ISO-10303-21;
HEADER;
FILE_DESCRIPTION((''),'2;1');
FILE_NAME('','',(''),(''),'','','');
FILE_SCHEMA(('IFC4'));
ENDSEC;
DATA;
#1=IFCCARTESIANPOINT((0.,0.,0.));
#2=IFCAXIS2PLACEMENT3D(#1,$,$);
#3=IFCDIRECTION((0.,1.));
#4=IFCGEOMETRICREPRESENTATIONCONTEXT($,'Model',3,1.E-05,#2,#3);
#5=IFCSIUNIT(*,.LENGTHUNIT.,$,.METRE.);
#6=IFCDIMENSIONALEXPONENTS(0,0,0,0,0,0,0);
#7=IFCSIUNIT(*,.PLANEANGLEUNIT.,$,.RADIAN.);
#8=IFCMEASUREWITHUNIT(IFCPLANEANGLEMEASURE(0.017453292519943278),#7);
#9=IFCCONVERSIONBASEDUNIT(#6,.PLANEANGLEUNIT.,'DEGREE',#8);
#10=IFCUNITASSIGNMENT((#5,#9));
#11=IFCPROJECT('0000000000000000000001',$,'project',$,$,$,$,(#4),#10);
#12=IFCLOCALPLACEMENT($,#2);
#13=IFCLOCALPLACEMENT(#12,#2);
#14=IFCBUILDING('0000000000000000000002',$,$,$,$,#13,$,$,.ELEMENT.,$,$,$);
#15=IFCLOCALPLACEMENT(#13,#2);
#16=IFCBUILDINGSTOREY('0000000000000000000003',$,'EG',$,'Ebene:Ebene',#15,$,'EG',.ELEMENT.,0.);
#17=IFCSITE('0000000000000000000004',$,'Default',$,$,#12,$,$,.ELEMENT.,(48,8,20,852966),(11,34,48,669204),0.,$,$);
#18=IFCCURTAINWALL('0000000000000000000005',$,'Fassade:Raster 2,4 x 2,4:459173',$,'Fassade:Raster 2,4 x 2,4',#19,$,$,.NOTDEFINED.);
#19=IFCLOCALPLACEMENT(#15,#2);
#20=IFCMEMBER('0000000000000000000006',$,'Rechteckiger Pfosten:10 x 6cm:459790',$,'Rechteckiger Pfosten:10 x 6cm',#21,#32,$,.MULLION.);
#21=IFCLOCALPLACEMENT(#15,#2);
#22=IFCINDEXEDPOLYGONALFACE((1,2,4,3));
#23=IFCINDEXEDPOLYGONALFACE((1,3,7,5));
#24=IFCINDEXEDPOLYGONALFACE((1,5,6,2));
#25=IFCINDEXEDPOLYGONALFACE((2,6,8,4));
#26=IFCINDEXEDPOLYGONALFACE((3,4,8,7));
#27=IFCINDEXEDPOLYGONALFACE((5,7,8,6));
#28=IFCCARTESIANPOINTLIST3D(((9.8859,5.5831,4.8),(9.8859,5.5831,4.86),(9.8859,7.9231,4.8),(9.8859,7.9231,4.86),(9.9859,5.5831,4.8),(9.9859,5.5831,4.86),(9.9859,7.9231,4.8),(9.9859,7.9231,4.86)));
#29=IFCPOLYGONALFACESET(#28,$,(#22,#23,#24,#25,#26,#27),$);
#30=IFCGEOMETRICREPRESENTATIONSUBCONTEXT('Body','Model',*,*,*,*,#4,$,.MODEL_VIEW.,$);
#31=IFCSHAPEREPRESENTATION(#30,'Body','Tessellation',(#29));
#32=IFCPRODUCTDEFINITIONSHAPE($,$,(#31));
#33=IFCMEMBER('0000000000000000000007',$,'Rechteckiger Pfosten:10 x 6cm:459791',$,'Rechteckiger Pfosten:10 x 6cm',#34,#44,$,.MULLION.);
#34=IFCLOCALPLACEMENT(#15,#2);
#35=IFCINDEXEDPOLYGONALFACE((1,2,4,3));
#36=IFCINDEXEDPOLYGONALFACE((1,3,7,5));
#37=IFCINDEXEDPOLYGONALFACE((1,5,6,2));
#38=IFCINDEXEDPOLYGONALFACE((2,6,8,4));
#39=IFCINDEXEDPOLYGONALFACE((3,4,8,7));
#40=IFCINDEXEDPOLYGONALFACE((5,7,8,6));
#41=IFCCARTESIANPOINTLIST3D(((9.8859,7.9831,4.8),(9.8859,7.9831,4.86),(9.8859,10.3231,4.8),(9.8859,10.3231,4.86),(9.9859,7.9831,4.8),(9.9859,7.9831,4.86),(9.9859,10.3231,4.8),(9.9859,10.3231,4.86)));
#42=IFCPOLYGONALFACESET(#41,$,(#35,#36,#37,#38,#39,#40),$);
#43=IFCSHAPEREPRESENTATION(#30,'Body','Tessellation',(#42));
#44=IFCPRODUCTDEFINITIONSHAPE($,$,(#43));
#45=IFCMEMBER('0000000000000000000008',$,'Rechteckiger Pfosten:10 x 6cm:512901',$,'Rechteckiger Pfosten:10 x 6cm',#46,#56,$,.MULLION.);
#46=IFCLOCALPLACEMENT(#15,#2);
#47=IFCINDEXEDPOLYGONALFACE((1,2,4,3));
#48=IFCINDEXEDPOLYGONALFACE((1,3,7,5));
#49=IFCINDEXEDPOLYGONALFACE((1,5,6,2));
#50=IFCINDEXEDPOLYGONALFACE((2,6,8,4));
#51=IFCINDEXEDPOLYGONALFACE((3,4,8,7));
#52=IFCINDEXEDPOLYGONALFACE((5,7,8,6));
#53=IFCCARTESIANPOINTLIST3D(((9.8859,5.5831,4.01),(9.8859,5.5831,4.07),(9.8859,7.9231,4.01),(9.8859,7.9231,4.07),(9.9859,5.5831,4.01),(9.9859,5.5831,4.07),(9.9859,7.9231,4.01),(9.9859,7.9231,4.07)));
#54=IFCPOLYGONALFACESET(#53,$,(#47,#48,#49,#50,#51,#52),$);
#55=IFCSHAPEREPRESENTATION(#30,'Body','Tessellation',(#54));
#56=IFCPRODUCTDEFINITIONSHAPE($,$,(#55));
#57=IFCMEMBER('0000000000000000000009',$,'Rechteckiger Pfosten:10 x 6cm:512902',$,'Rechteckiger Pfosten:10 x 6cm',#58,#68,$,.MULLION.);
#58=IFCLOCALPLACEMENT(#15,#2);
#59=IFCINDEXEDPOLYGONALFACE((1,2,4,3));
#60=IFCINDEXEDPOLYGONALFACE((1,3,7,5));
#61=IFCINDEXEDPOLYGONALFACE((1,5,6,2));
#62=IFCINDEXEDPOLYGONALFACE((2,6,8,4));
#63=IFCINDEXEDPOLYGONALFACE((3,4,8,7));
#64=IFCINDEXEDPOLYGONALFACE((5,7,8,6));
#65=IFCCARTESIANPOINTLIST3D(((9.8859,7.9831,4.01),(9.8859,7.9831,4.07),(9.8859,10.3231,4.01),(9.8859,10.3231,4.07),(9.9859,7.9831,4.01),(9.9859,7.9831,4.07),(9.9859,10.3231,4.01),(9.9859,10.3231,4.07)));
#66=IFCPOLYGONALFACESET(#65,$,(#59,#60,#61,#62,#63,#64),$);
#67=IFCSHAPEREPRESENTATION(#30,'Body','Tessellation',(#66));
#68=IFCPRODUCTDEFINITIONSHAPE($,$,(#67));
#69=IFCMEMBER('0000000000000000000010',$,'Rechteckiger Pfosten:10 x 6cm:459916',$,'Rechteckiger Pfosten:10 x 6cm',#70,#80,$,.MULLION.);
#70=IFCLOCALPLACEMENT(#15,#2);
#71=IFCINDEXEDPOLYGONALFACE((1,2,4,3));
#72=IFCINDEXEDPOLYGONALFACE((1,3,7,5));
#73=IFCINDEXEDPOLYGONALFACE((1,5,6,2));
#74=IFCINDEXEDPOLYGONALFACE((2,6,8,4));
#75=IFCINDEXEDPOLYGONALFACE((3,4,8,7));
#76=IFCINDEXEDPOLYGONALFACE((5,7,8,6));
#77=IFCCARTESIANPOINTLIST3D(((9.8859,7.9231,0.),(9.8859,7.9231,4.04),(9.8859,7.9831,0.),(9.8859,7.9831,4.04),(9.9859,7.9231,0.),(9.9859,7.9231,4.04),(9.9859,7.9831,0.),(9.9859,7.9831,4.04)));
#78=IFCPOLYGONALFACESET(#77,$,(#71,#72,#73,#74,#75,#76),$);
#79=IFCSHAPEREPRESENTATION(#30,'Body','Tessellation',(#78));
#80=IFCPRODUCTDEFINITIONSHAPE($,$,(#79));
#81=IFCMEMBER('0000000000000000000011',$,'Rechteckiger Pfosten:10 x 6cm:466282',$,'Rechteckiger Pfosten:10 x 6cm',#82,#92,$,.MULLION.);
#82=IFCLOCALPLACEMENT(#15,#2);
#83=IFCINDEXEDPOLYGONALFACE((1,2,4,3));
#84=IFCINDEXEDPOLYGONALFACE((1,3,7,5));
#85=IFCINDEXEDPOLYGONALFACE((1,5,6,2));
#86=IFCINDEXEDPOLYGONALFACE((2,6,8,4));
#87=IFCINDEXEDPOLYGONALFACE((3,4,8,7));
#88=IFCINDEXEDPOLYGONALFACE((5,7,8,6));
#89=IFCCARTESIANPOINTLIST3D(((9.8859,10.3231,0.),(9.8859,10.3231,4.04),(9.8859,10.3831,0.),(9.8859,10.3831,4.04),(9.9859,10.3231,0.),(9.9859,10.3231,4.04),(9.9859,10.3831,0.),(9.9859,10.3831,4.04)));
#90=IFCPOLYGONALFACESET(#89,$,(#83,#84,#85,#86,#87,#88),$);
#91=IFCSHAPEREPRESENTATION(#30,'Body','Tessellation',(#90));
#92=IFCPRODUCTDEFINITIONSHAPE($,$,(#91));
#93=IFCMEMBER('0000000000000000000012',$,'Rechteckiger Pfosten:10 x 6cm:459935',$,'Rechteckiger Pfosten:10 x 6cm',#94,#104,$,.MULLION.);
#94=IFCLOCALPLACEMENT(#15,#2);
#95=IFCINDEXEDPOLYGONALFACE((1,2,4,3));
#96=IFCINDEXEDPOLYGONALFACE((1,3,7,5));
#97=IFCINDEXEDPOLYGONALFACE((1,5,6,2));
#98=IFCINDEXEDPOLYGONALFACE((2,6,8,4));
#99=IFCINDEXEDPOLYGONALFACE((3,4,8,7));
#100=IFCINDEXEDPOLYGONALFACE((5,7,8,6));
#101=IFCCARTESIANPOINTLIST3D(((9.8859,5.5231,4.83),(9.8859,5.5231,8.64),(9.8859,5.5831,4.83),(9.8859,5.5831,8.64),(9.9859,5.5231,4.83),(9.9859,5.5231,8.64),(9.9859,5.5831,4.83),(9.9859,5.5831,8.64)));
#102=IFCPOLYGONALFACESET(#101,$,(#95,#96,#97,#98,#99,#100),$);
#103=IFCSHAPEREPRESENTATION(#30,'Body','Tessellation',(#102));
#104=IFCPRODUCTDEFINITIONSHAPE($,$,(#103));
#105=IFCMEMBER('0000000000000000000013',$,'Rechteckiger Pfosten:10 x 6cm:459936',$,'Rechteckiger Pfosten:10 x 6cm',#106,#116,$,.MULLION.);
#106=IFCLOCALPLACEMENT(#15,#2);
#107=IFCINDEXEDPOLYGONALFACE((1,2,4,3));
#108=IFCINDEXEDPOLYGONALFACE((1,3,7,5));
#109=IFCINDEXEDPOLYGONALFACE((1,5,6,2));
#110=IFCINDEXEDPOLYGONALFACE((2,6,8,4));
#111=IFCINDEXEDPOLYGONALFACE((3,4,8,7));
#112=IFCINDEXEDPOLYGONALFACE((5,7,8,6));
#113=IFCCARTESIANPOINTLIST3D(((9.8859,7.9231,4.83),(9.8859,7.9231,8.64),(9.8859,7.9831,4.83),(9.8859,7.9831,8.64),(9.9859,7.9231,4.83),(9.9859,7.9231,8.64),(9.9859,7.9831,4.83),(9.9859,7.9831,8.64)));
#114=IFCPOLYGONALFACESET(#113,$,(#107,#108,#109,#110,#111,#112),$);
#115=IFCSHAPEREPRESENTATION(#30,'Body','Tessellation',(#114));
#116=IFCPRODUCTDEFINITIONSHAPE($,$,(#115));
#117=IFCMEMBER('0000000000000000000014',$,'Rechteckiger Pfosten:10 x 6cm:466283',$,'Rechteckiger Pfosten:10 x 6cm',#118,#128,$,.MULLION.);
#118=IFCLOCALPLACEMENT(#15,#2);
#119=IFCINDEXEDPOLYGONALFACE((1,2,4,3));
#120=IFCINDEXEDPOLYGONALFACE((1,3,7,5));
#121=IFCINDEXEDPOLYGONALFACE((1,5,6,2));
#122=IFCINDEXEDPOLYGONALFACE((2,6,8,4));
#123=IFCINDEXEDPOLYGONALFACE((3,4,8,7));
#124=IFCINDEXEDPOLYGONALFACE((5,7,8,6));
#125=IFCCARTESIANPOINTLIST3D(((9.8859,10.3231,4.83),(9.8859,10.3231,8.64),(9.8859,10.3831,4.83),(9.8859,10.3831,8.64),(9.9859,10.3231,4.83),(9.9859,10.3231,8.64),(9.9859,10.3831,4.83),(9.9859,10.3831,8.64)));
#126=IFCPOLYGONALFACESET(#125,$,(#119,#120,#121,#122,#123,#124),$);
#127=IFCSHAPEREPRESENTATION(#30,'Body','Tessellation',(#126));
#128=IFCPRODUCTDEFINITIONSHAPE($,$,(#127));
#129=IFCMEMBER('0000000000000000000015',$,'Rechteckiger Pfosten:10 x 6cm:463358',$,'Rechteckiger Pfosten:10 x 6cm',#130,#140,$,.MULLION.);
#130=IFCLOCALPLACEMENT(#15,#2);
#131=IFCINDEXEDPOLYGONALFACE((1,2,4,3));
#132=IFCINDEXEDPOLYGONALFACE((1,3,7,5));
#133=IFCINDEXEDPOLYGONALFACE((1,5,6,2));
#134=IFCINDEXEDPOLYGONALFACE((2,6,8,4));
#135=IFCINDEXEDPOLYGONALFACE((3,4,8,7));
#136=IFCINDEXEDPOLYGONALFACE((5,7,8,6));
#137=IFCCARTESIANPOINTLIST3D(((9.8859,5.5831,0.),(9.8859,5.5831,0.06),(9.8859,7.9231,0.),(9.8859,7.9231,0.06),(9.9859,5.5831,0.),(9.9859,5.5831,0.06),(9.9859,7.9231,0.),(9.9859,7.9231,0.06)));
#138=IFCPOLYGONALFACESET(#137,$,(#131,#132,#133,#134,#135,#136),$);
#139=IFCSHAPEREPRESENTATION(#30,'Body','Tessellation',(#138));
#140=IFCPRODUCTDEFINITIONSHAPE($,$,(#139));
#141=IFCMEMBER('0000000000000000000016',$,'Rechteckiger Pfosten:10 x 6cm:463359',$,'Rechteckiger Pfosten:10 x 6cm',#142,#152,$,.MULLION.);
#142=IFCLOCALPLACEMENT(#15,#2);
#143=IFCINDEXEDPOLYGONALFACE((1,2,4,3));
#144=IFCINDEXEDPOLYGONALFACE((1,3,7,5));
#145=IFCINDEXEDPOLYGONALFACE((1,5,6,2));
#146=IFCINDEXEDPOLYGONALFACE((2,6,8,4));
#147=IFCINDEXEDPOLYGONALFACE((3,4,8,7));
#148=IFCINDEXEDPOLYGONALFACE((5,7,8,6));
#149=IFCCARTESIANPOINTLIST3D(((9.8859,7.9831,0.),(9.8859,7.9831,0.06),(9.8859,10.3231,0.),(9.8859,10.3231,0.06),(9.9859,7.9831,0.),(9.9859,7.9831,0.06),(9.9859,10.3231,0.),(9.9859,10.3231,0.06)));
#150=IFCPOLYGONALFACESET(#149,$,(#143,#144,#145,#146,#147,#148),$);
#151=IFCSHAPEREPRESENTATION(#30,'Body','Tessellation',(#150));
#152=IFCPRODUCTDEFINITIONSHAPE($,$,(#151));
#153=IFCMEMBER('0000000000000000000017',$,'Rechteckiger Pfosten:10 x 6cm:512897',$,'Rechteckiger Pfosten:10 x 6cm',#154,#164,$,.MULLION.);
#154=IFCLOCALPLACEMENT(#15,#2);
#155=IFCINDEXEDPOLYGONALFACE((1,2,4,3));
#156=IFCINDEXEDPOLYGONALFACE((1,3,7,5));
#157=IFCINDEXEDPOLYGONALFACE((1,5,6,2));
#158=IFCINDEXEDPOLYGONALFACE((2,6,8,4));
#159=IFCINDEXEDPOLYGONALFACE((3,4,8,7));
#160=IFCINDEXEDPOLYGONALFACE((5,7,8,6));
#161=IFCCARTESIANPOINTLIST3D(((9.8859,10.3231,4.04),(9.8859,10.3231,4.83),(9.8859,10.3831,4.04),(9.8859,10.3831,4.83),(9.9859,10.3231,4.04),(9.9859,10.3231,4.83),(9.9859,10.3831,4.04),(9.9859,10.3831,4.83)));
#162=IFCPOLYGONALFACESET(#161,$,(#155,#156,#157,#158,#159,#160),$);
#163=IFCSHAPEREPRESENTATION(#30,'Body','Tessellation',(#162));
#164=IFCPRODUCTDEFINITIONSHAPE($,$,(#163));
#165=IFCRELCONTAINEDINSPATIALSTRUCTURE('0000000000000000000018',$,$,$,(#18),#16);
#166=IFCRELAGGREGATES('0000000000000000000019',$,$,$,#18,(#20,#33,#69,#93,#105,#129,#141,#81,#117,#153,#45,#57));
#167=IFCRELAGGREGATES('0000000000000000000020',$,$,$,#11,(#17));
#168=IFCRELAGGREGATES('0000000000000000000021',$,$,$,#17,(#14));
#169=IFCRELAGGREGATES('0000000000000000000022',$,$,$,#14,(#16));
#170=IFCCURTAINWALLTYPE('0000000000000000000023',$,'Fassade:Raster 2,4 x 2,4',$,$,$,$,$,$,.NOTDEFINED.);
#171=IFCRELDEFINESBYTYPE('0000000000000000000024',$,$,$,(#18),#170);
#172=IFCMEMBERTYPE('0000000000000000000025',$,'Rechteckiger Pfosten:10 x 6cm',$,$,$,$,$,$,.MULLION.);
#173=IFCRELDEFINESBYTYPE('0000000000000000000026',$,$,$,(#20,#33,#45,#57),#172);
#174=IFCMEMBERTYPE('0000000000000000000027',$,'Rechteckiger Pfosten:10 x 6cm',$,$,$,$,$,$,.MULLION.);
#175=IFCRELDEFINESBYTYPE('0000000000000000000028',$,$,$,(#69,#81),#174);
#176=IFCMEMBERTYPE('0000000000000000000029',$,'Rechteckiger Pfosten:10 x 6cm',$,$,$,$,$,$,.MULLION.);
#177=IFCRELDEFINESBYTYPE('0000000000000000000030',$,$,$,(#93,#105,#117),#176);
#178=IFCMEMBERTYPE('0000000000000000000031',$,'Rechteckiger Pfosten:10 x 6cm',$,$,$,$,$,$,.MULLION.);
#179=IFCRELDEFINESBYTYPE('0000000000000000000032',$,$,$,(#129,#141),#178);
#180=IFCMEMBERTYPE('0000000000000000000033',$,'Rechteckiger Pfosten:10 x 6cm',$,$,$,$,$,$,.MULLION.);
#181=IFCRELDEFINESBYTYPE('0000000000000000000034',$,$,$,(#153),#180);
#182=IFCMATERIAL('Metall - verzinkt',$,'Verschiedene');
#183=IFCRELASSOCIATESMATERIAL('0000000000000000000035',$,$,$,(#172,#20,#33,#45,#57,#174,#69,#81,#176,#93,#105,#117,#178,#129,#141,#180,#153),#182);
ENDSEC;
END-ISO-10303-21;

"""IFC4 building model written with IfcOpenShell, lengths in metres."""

from ifc_helpers import new_model, entity, si_unit, converted_unit, direction, frame, origin, place, context, subcontext, project, spatial, indexed_curve, outline, extrude, source, transform, mapped, material, type_object, type_shapes, element, aggregate, save


model = new_model("IFC4")

# Units and contexts
model_context = context("Model", 3, precision=1e-05, world=origin(), true_north=direction((0.0, 1.0)))
body_context = subcontext(model_context, "Body", "Model", "MODEL_VIEW")
ifc_project = project(units=[si_unit("LENGTHUNIT", "METRE"), converted_unit("PLANEANGLEUNIT", "DEGREE", entity("IfcPlaneAngleMeasure", 0.017453292519943278), si_unit("PLANEANGLEUNIT", "RADIAN"), dimensions=[0, 0, 0, 0, 0, 0, 0])], contexts=[model_context])

# Site, building, storey
site_placement = place(None, origin())
site = spatial("IfcSite", under=ifc_project, at=site_placement, Name="Default", CompositionType="ELEMENT", RefLatitude=(48, 8, 20, 852966), RefLongitude=(11, 34, 48, 669204), RefElevation=0.0)
building_placement = place(site_placement, origin())
building = spatial("IfcBuilding", under=site, at=building_placement, CompositionType="ELEMENT")
storey_placement = place(building_placement, origin())
storey = spatial("IfcBuildingStorey", under=building, at=storey_placement, Name="EG", ObjectType="Ebene:Ebene", LongName="EG", CompositionType="ELEMENT", Elevation=0.0)

# Curtain wall, members
curtain_wall_type = type_object("IfcCurtainWallType", Name="Fassade:Raster 2,4 x 2,4", PredefinedType="NOTDEFINED")
curtain_wall_placement = place(storey_placement, origin())
curtain_wall = element("IfcCurtainWall", 1, at=curtain_wall_placement, inside=storey, type_object=curtain_wall_type, Name="Fassade:Raster 2,4 x 2,4:459173", ObjectType="Fassade:Raster 2,4 x 2,4", PredefinedType="NOTDEFINED")
ifc_material_1 = material(Name="Metall - verzinkt", Category="Verschiedene")
member_type_1 = type_object("IfcMemberType", Name="Rechteckiger Pfosten:10 x 6cm", PredefinedType="MULLION", material=ifc_material_1)
shared_shape_1 = source(origin(), body_context, "Body", "SweptSolid", [
    extrude(outline(indexed_curve([(-0.03, -0.05), (0.03, -0.05), (0.03, 0.05), (-0.03, 0.05), (-0.03, -0.05)], self_intersect=False)), frame((0.0, 0.0, -2.34), z_axis=(0.0, 0.0, 1.0), x_axis=(-1.0, 0.0, 0.0)), (0.0, 0.0, 1.0), 2.34),
])
type_shapes(member_type_1, [shared_shape_1])
member_1_placement = place(curtain_wall_placement, frame((9.9359, 7.9231, 4.83), z_axis=(0.0, 1.0, 0.0), x_axis=(0.0, 0.0, 1.0)))
member_1 = element("IfcMember", 2, at=member_1_placement, type_object=member_type_1, material=ifc_material_1, Name="Rechteckiger Pfosten:10 x 6cm:459790", ObjectType="Rechteckiger Pfosten:10 x 6cm", PredefinedType="MULLION", context=body_context, shape_type="MappedRepresentation", body=[
    mapped(shared_shape_1, transform((0.0, 0.0, 0.0), scale=1.0)),
])
member_2_placement = place(curtain_wall_placement, frame((9.9359, 10.3231, 4.83), z_axis=(0.0, 1.0, 0.0), x_axis=(0.0, 0.0, 1.0)))
member_2 = element("IfcMember", 3, at=member_2_placement, type_object=member_type_1, material=ifc_material_1, Name="Rechteckiger Pfosten:10 x 6cm:459791", ObjectType="Rechteckiger Pfosten:10 x 6cm", PredefinedType="MULLION", context=body_context, shape_type="MappedRepresentation", body=[
    mapped(shared_shape_1, transform((0.0, 0.0, 0.0), scale=1.0)),
])
member_3_placement = place(curtain_wall_placement, frame((9.9359, 7.9231, 4.04), z_axis=(0.0, 1.0, 0.0), x_axis=(0.0, 0.0, 1.0)))
member_3 = element("IfcMember", 4, at=member_3_placement, type_object=member_type_1, material=ifc_material_1, Name="Rechteckiger Pfosten:10 x 6cm:512901", ObjectType="Rechteckiger Pfosten:10 x 6cm", PredefinedType="MULLION", context=body_context, shape_type="MappedRepresentation", body=[
    mapped(shared_shape_1, transform((0.0, 0.0, 0.0), scale=1.0)),
])
member_4_placement = place(curtain_wall_placement, frame((9.9359, 10.3231, 4.04), z_axis=(0.0, 1.0, 0.0), x_axis=(0.0, 0.0, 1.0)))
member_4 = element("IfcMember", 5, at=member_4_placement, type_object=member_type_1, material=ifc_material_1, Name="Rechteckiger Pfosten:10 x 6cm:512902", ObjectType="Rechteckiger Pfosten:10 x 6cm", PredefinedType="MULLION", context=body_context, shape_type="MappedRepresentation", body=[
    mapped(shared_shape_1, transform((0.0, 0.0, 0.0), scale=1.0)),
])
member_type_2 = type_object("IfcMemberType", Name="Rechteckiger Pfosten:10 x 6cm", PredefinedType="MULLION", material=ifc_material_1)
shared_shape_2 = source(origin(), body_context, "Body", "SweptSolid", [
    extrude(outline(indexed_curve([(-0.03, -0.05), (0.03, -0.05), (0.03, 0.05), (-0.03, 0.05), (-0.03, -0.05)], self_intersect=False)), frame((0.0, 0.0, -4.04), z_axis=(0.0, 0.0, 1.0), x_axis=(-1.0, 0.0, 0.0)), (0.0, 0.0, 1.0), 4.04),
])
type_shapes(member_type_2, [shared_shape_2])
member_5_placement = place(curtain_wall_placement, frame((9.9359, 7.9531, 0.0), z_axis=(0.0, 0.0, -1.0), x_axis=(0.0, 1.0, 0.0)))
member_5 = element("IfcMember", 6, at=member_5_placement, type_object=member_type_2, material=ifc_material_1, Name="Rechteckiger Pfosten:10 x 6cm:459916", ObjectType="Rechteckiger Pfosten:10 x 6cm", PredefinedType="MULLION", context=body_context, shape_type="MappedRepresentation", body=[
    mapped(shared_shape_2, transform((0.0, 0.0, 0.0), scale=1.0)),
])
member_6_placement = place(curtain_wall_placement, frame((9.9359, 10.3531, 0.0), z_axis=(0.0, 0.0, -1.0), x_axis=(0.0, 1.0, 0.0)))
member_6 = element("IfcMember", 7, at=member_6_placement, type_object=member_type_2, material=ifc_material_1, Name="Rechteckiger Pfosten:10 x 6cm:466282", ObjectType="Rechteckiger Pfosten:10 x 6cm", PredefinedType="MULLION", context=body_context, shape_type="MappedRepresentation", body=[
    mapped(shared_shape_2, transform((0.0, 0.0, 0.0), scale=1.0)),
])
member_type_3 = type_object("IfcMemberType", Name="Rechteckiger Pfosten:10 x 6cm", PredefinedType="MULLION", material=ifc_material_1)
shared_shape_3 = source(origin(), body_context, "Body", "SweptSolid", [
    extrude(outline(indexed_curve([(-0.03, -0.05), (0.03, -0.05), (0.03, 0.05), (-0.03, 0.05), (-0.03, -0.05)], self_intersect=False)), frame((0.0, 0.0, -3.81), z_axis=(0.0, 0.0, 1.0), x_axis=(-1.0, 0.0, 0.0)), (0.0, 0.0, 1.0), 3.81),
])
type_shapes(member_type_3, [shared_shape_3])
member_7_placement = place(curtain_wall_placement, frame((9.9359, 5.5531, 4.83), z_axis=(0.0, 0.0, -1.0), x_axis=(0.0, 1.0, 0.0)))
member_7 = element("IfcMember", 8, at=member_7_placement, type_object=member_type_3, material=ifc_material_1, Name="Rechteckiger Pfosten:10 x 6cm:459935", ObjectType="Rechteckiger Pfosten:10 x 6cm", PredefinedType="MULLION", context=body_context, shape_type="MappedRepresentation", body=[
    mapped(shared_shape_3, transform((0.0, 0.0, 0.0), scale=1.0)),
])
member_8_placement = place(curtain_wall_placement, frame((9.9359, 7.9531, 4.83), z_axis=(0.0, 0.0, -1.0), x_axis=(0.0, 1.0, 0.0)))
member_8 = element("IfcMember", 9, at=member_8_placement, type_object=member_type_3, material=ifc_material_1, Name="Rechteckiger Pfosten:10 x 6cm:459936", ObjectType="Rechteckiger Pfosten:10 x 6cm", PredefinedType="MULLION", context=body_context, shape_type="MappedRepresentation", body=[
    mapped(shared_shape_3, transform((0.0, 0.0, 0.0), scale=1.0)),
])
member_9_placement = place(curtain_wall_placement, frame((9.9359, 10.3531, 4.83), z_axis=(0.0, 0.0, -1.0), x_axis=(0.0, 1.0, 0.0)))
member_9 = element("IfcMember", 10, at=member_9_placement, type_object=member_type_3, material=ifc_material_1, Name="Rechteckiger Pfosten:10 x 6cm:466283", ObjectType="Rechteckiger Pfosten:10 x 6cm", PredefinedType="MULLION", context=body_context, shape_type="MappedRepresentation", body=[
    mapped(shared_shape_3, transform((0.0, 0.0, 0.0), scale=1.0)),
])
member_type_4 = type_object("IfcMemberType", Name="Rechteckiger Pfosten:10 x 6cm", PredefinedType="MULLION", material=ifc_material_1)
shared_shape_4 = source(origin(), body_context, "Body", "SweptSolid", [
    extrude(outline(indexed_curve([(-0.03, -0.05), (0.03, -0.05), (0.03, 0.05), (-0.03, 0.05), (-0.03, -0.05)], self_intersect=False)), frame((-0.03, 0.0, -2.34), z_axis=(0.0, 0.0, 1.0), x_axis=(-1.0, 0.0, 0.0)), (0.0, 0.0, 1.0), 2.34),
])
type_shapes(member_type_4, [shared_shape_4])
member_10_placement = place(curtain_wall_placement, frame((9.9359, 5.5831, 0.0), z_axis=(0.0, -1.0, 0.0), x_axis=(0.0, 0.0, -1.0)))
member_10 = element("IfcMember", 11, at=member_10_placement, type_object=member_type_4, material=ifc_material_1, Name="Rechteckiger Pfosten:10 x 6cm:463358", ObjectType="Rechteckiger Pfosten:10 x 6cm", PredefinedType="MULLION", context=body_context, shape_type="MappedRepresentation", body=[
    mapped(shared_shape_4, transform((0.0, 0.0, 0.0), scale=1.0)),
])
member_11_placement = place(curtain_wall_placement, frame((9.9359, 7.9831, 0.0), z_axis=(0.0, -1.0, 0.0), x_axis=(0.0, 0.0, -1.0)))
member_11 = element("IfcMember", 12, at=member_11_placement, type_object=member_type_4, material=ifc_material_1, Name="Rechteckiger Pfosten:10 x 6cm:463359", ObjectType="Rechteckiger Pfosten:10 x 6cm", PredefinedType="MULLION", context=body_context, shape_type="MappedRepresentation", body=[
    mapped(shared_shape_4, transform((0.0, 0.0, 0.0), scale=1.0)),
])
member_type_5 = type_object("IfcMemberType", Name="Rechteckiger Pfosten:10 x 6cm", PredefinedType="MULLION", material=ifc_material_1)
shared_shape_5 = source(origin(), body_context, "Body", "SweptSolid", [
    extrude(outline(indexed_curve([(-0.03, -0.05), (0.03, -0.05), (0.03, 0.05), (-0.03, 0.05), (-0.03, -0.05)], self_intersect=False)), frame((-0.03, 0.0, -0.79), z_axis=(0.0, 0.0, 1.0), x_axis=(-1.0, 0.0, 0.0)), (0.0, 0.0, 1.0), 0.79),
])
type_shapes(member_type_5, [shared_shape_5])
member_12_placement = place(curtain_wall_placement, frame((9.9359, 10.3831, 4.04), z_axis=(0.0, 0.0, -1.0), x_axis=(0.0, 1.0, 0.0)))
member_12 = element("IfcMember", 13, at=member_12_placement, type_object=member_type_5, material=ifc_material_1, Name="Rechteckiger Pfosten:10 x 6cm:512897", ObjectType="Rechteckiger Pfosten:10 x 6cm", PredefinedType="MULLION", context=body_context, shape_type="MappedRepresentation", body=[
    mapped(shared_shape_5, transform((0.0, 0.0, 0.0), scale=1.0)),
])
aggregate(curtain_wall, [member_1, member_2, member_5, member_7, member_8, member_10, member_11, member_6, member_9, member_12, member_3, member_4])

save(model, "model.ifc")
